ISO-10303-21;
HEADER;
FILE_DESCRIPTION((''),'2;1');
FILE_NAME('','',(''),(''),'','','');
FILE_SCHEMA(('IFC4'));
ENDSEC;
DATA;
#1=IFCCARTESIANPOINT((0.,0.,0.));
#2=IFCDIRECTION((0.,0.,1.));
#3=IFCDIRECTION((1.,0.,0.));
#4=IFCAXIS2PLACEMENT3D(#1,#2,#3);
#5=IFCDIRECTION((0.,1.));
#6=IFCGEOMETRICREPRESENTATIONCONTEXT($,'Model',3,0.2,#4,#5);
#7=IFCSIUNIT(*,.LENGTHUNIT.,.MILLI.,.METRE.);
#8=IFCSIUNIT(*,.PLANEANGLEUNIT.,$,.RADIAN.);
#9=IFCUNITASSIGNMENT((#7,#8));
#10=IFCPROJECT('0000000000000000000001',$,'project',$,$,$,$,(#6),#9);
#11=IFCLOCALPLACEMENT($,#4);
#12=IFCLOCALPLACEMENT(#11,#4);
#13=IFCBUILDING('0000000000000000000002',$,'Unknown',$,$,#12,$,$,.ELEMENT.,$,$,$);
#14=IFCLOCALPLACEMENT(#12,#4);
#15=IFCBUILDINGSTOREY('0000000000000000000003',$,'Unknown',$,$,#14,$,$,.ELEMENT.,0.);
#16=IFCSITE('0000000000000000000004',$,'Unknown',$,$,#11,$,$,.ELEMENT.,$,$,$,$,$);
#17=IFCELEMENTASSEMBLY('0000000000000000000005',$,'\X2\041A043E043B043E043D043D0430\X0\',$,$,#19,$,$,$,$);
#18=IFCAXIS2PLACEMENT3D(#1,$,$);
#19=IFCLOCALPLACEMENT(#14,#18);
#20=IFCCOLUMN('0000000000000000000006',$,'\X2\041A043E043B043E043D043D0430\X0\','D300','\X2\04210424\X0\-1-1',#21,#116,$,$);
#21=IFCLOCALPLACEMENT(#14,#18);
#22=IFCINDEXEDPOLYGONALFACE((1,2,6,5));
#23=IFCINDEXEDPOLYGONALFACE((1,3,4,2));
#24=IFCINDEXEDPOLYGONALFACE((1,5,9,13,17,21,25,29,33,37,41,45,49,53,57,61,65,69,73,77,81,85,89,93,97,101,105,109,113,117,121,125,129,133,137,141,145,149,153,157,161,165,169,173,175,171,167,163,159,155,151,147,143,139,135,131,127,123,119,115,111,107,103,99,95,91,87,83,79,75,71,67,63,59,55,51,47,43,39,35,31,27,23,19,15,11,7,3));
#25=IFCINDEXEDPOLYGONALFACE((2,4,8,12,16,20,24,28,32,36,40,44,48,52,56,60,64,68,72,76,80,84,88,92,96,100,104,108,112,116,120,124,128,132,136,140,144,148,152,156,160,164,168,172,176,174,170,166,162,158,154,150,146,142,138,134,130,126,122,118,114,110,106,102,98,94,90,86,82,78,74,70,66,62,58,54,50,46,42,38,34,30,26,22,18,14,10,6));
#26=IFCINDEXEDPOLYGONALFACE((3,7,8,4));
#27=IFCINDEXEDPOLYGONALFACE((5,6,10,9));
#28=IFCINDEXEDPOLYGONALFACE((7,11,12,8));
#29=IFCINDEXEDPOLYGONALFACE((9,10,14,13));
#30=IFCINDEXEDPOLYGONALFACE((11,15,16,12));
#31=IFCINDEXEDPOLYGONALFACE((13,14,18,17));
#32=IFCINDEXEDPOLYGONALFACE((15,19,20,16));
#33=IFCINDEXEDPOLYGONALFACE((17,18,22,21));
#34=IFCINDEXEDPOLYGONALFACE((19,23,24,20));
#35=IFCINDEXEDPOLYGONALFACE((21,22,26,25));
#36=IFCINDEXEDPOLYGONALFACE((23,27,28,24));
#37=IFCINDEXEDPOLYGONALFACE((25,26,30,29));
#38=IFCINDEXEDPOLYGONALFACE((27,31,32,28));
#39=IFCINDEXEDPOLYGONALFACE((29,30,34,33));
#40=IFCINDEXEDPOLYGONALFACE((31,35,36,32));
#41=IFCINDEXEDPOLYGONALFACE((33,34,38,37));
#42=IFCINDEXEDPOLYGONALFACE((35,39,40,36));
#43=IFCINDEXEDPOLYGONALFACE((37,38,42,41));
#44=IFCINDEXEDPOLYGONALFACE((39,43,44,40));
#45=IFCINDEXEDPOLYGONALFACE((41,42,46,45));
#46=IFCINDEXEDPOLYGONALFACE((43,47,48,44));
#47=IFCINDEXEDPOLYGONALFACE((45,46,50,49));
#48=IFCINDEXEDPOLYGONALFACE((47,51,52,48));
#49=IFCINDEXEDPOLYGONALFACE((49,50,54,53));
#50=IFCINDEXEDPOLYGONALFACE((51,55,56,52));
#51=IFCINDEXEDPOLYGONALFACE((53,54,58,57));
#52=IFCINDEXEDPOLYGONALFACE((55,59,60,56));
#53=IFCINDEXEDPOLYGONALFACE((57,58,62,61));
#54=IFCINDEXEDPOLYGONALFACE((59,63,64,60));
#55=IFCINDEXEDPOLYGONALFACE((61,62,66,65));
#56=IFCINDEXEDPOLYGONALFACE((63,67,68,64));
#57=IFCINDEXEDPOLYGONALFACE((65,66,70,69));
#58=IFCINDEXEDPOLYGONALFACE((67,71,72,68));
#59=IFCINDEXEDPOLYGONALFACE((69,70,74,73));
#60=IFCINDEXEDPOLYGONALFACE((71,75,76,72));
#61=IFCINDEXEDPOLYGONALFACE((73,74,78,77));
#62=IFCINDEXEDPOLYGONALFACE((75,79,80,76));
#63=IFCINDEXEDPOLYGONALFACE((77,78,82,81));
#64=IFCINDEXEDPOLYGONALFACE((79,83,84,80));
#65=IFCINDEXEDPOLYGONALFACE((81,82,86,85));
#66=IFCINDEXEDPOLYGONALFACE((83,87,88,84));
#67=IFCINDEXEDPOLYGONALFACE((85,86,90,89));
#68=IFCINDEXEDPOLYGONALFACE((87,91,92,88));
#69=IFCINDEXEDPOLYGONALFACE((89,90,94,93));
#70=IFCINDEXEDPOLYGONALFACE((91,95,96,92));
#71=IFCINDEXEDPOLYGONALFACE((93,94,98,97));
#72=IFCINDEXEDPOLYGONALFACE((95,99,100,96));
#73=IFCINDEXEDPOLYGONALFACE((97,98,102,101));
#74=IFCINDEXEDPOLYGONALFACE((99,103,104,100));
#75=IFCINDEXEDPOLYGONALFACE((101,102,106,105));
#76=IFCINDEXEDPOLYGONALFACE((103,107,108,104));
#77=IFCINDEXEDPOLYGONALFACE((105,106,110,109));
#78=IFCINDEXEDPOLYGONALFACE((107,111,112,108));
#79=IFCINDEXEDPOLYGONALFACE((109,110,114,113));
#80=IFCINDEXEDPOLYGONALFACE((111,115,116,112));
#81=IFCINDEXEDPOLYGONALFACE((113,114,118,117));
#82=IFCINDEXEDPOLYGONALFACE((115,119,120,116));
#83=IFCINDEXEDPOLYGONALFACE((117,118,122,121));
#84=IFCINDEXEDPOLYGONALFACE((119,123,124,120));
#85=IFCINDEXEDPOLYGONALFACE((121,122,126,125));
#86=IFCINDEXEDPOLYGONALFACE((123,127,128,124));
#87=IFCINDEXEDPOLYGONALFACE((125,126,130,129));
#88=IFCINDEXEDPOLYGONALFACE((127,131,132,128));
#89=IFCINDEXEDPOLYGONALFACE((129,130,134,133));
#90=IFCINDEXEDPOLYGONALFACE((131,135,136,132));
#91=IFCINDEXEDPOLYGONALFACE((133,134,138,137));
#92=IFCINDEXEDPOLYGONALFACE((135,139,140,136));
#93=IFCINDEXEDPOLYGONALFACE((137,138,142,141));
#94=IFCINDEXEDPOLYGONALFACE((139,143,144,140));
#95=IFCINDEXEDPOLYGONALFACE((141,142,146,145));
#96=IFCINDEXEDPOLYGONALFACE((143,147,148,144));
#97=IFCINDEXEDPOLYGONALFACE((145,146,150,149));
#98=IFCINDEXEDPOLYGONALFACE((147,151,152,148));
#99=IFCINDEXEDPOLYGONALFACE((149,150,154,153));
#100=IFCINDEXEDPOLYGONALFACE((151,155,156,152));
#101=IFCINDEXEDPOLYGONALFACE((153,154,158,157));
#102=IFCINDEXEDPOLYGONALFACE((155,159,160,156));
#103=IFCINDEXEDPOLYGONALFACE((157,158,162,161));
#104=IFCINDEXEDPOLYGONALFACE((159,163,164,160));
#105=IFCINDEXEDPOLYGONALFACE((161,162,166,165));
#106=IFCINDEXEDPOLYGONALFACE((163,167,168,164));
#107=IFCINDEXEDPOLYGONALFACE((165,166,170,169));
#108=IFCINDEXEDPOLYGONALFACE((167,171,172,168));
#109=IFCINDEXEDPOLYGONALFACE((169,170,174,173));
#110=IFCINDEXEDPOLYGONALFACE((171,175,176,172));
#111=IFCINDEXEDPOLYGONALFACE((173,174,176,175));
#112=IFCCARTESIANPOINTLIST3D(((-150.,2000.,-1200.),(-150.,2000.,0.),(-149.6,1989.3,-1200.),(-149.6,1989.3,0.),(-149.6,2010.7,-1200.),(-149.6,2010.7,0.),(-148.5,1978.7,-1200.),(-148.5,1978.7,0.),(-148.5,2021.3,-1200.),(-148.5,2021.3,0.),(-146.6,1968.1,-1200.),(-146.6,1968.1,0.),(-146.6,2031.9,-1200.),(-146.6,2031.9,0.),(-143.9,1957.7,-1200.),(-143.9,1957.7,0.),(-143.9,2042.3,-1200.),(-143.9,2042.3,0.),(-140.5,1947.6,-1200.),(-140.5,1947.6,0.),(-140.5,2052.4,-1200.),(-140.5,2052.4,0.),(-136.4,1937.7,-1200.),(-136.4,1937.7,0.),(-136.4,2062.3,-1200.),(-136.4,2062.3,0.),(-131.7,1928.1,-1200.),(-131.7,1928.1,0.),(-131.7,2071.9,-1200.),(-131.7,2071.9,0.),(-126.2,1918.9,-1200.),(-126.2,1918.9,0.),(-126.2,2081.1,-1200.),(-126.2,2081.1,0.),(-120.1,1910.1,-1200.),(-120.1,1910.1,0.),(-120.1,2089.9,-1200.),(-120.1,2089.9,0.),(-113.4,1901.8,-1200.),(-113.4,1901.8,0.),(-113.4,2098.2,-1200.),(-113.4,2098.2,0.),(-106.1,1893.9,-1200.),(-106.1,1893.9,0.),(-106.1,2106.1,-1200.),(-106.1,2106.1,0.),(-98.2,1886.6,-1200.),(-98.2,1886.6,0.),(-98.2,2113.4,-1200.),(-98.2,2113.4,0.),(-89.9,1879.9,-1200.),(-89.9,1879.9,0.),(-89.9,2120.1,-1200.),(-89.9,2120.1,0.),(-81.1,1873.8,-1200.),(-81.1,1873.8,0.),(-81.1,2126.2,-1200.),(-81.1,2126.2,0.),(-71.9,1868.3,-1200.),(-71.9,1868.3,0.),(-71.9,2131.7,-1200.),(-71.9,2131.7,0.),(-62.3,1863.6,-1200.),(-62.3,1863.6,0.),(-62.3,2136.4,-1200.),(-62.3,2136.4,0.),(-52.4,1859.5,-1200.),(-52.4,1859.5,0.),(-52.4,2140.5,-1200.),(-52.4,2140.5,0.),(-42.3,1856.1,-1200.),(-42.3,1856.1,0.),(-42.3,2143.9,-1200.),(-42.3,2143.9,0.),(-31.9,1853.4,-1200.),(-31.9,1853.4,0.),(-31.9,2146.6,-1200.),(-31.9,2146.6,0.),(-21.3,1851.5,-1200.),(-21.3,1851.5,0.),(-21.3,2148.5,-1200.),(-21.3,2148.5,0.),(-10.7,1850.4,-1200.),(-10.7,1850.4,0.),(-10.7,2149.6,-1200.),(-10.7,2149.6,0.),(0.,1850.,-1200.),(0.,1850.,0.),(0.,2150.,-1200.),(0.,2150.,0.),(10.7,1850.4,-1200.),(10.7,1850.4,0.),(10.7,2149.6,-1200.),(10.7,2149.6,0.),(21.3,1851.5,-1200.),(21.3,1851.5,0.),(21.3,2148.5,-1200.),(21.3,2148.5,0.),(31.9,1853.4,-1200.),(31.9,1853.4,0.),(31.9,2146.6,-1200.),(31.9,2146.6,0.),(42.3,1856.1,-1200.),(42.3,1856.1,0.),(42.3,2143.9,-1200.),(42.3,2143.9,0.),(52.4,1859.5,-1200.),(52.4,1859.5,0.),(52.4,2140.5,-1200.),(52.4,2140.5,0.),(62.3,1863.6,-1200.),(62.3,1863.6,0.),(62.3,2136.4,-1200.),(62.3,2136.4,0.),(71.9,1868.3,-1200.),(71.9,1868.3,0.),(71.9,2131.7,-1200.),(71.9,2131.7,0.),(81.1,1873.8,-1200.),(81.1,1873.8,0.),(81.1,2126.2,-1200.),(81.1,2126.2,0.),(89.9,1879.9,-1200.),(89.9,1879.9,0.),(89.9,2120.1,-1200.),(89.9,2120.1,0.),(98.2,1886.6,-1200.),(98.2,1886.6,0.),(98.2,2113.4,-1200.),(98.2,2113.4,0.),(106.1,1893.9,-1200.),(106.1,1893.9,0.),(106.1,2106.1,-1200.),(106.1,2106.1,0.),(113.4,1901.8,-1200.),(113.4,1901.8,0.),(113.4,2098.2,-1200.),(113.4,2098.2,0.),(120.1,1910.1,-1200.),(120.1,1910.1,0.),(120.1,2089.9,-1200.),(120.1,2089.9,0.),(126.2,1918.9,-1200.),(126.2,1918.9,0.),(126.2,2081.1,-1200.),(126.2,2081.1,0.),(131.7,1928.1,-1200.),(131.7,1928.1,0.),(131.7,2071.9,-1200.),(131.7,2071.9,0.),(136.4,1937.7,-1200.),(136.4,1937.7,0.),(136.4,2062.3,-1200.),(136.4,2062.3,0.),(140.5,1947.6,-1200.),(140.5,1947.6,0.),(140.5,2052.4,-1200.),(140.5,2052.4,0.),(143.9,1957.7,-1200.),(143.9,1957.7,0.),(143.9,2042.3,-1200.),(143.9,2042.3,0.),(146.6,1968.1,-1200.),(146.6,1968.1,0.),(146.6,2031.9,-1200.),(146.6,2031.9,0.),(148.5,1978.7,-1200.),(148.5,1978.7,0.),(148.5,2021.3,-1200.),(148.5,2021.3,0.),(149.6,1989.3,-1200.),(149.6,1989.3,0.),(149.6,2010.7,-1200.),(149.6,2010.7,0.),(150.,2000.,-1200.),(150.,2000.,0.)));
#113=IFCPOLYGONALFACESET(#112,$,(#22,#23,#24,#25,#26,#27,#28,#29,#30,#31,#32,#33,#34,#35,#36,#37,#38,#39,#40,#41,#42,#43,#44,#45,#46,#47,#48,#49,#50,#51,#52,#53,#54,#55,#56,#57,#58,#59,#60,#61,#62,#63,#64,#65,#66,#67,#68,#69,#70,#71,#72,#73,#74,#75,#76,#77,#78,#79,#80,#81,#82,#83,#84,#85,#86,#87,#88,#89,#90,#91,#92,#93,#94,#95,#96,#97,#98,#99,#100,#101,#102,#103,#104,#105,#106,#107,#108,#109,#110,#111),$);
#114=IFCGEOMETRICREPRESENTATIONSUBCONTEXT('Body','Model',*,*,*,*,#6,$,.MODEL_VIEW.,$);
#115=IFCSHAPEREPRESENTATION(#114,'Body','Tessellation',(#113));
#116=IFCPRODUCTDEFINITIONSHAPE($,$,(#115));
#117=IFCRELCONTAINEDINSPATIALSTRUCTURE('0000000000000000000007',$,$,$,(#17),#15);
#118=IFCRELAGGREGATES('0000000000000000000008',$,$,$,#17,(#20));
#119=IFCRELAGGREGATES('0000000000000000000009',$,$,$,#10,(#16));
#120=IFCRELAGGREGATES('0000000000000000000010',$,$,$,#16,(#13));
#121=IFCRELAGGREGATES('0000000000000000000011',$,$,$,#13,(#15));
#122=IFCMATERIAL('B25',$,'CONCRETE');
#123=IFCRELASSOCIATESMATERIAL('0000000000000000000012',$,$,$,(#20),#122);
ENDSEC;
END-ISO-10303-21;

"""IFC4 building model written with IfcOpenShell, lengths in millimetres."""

from ifc_helpers import new_model, si_unit, direction, frame, origin_with_axes, place, context, subcontext, project, spatial, line, indexed_curve, outline, extrude, material, element, aggregate, save


model = new_model("IFC4")

# Units and contexts
model_context = context("Model", 3, precision=0.2, world=origin_with_axes(), true_north=direction((0.0, 1.0)))
body_context = subcontext(model_context, "Body", "Model", "MODEL_VIEW")
ifc_project = project(units=[si_unit("LENGTHUNIT", "METRE", prefix="MILLI"), si_unit("PLANEANGLEUNIT", "RADIAN")], contexts=[model_context])

# Site, building, storey
site_placement = place(None, origin_with_axes())
site = spatial("IfcSite", under=ifc_project, at=site_placement, Name="Unknown", CompositionType="ELEMENT")
building_placement = place(site_placement, origin_with_axes())
building = spatial("IfcBuilding", under=site, at=building_placement, Name="Unknown", CompositionType="ELEMENT")
storey_placement = place(building_placement, origin_with_axes())
storey = spatial("IfcBuildingStorey", under=building, at=storey_placement, Name="Unknown", CompositionType="ELEMENT", Elevation=0.0)

# Element assembly, column
assembly_1_placement = place(storey_placement, frame((0.0, 2000.0, -1200.0), z_axis=(-1.0, 0.0, 0.0), x_axis=(0.0, 0.0, 1.0)))
assembly_1 = element("IfcElementAssembly", 1, at=assembly_1_placement, inside=storey, Name="Колонна")
ifc_material_1 = material(Name="B25", Category="CONCRETE")
column_1_placement = place(assembly_1_placement, origin_with_axes())
column_1 = element("IfcColumn", 2, at=column_1_placement, material=ifc_material_1, Name="Колонна", Description="D300", ObjectType="СФ-1-1", context=body_context, shape_type="SolidModel", body=[
    extrude(outline(indexed_curve([(150.0, 0.0), (149.6, 10.7), (148.5, 21.3), (146.6, 31.9), (143.9, 42.3), (140.5, 52.4), (136.4, 62.3), (131.7, 71.9), (126.2, 81.1), (120.1, 89.9), (113.4, 98.2), (106.1, 106.1), (98.2, 113.4), (89.9, 120.1), (81.1, 126.2), (71.9, 131.7), (62.3, 136.4), (52.4, 140.5), (42.3, 143.9), (31.9, 146.6), (21.3, 148.5), (10.7, 149.6), (0.0, 150.0), (-10.7, 149.6), (-21.3, 148.5), (-31.9, 146.6), (-42.3, 143.9), (-52.4, 140.5), (-62.3, 136.4), (-71.9, 131.7), (-81.1, 126.2), (-89.9, 120.1), (-98.2, 113.4), (-106.1, 106.1), (-113.4, 98.2), (-120.1, 89.9), (-126.2, 81.1), (-131.7, 71.9), (-136.4, 62.3), (-140.5, 52.4), (-143.9, 42.3), (-146.6, 31.9), (-148.5, 21.3), (-149.6, 10.7), (-150.0, 0.0), (-149.6, -10.7), (-148.5, -21.3), (-146.6, -31.9), (-143.9, -42.3), (-140.5, -52.4), (-136.4, -62.3), (-131.7, -71.9), (-126.2, -81.1), (-120.1, -89.9), (-113.4, -98.2), (-106.1, -106.1), (-98.2, -113.4), (-89.9, -120.1), (-81.1, -126.2), (-71.9, -131.7), (-62.3, -136.4), (-52.4, -140.5), (-42.3, -143.9), (-31.9, -146.6), (-21.3, -148.5), (-10.7, -149.6), (0.0, -150.0), (10.7, -149.6), (21.3, -148.5), (31.9, -146.6), (42.3, -143.9), (52.4, -140.5), (62.3, -136.4), (71.9, -131.7), (81.1, -126.2), (89.9, -120.1), (98.2, -113.4), (106.1, -106.1), (113.4, -98.2), (120.1, -89.9), (126.2, -81.1), (131.7, -71.9), (136.4, -62.3), (140.5, -52.4), (143.9, -42.3), (146.6, -31.9), (148.5, -21.3), (149.6, -10.7)], segments=[line(1, 2, 3, 4, 5, 6, 7, 8, 9, 10, 11, 12, 13, 14, 15, 16, 17, 18, 19, 20, 21, 22, 23, 24, 25, 26, 27, 28, 29, 30, 31, 32, 33, 34, 35, 36, 37, 38, 39, 40, 41, 42, 43, 44, 45, 46, 47, 48, 49, 50, 51, 52, 53, 54, 55, 56, 57, 58, 59, 60, 61, 62, 63, 64, 65, 66, 67, 68, 69, 70, 71, 72, 73, 74, 75, 76, 77, 78, 79, 80, 81, 82, 83, 84, 85, 86, 87, 88, 1)])), frame((0.0, 0.0, 0.0), z_axis=(-1.0, 0.0, 0.0), x_axis=(0.0, 0.0, 1.0)), (0.0, 0.0, -1.0), 1200.0),
])
aggregate(assembly_1, [column_1])

save(model, "model.ifc")
